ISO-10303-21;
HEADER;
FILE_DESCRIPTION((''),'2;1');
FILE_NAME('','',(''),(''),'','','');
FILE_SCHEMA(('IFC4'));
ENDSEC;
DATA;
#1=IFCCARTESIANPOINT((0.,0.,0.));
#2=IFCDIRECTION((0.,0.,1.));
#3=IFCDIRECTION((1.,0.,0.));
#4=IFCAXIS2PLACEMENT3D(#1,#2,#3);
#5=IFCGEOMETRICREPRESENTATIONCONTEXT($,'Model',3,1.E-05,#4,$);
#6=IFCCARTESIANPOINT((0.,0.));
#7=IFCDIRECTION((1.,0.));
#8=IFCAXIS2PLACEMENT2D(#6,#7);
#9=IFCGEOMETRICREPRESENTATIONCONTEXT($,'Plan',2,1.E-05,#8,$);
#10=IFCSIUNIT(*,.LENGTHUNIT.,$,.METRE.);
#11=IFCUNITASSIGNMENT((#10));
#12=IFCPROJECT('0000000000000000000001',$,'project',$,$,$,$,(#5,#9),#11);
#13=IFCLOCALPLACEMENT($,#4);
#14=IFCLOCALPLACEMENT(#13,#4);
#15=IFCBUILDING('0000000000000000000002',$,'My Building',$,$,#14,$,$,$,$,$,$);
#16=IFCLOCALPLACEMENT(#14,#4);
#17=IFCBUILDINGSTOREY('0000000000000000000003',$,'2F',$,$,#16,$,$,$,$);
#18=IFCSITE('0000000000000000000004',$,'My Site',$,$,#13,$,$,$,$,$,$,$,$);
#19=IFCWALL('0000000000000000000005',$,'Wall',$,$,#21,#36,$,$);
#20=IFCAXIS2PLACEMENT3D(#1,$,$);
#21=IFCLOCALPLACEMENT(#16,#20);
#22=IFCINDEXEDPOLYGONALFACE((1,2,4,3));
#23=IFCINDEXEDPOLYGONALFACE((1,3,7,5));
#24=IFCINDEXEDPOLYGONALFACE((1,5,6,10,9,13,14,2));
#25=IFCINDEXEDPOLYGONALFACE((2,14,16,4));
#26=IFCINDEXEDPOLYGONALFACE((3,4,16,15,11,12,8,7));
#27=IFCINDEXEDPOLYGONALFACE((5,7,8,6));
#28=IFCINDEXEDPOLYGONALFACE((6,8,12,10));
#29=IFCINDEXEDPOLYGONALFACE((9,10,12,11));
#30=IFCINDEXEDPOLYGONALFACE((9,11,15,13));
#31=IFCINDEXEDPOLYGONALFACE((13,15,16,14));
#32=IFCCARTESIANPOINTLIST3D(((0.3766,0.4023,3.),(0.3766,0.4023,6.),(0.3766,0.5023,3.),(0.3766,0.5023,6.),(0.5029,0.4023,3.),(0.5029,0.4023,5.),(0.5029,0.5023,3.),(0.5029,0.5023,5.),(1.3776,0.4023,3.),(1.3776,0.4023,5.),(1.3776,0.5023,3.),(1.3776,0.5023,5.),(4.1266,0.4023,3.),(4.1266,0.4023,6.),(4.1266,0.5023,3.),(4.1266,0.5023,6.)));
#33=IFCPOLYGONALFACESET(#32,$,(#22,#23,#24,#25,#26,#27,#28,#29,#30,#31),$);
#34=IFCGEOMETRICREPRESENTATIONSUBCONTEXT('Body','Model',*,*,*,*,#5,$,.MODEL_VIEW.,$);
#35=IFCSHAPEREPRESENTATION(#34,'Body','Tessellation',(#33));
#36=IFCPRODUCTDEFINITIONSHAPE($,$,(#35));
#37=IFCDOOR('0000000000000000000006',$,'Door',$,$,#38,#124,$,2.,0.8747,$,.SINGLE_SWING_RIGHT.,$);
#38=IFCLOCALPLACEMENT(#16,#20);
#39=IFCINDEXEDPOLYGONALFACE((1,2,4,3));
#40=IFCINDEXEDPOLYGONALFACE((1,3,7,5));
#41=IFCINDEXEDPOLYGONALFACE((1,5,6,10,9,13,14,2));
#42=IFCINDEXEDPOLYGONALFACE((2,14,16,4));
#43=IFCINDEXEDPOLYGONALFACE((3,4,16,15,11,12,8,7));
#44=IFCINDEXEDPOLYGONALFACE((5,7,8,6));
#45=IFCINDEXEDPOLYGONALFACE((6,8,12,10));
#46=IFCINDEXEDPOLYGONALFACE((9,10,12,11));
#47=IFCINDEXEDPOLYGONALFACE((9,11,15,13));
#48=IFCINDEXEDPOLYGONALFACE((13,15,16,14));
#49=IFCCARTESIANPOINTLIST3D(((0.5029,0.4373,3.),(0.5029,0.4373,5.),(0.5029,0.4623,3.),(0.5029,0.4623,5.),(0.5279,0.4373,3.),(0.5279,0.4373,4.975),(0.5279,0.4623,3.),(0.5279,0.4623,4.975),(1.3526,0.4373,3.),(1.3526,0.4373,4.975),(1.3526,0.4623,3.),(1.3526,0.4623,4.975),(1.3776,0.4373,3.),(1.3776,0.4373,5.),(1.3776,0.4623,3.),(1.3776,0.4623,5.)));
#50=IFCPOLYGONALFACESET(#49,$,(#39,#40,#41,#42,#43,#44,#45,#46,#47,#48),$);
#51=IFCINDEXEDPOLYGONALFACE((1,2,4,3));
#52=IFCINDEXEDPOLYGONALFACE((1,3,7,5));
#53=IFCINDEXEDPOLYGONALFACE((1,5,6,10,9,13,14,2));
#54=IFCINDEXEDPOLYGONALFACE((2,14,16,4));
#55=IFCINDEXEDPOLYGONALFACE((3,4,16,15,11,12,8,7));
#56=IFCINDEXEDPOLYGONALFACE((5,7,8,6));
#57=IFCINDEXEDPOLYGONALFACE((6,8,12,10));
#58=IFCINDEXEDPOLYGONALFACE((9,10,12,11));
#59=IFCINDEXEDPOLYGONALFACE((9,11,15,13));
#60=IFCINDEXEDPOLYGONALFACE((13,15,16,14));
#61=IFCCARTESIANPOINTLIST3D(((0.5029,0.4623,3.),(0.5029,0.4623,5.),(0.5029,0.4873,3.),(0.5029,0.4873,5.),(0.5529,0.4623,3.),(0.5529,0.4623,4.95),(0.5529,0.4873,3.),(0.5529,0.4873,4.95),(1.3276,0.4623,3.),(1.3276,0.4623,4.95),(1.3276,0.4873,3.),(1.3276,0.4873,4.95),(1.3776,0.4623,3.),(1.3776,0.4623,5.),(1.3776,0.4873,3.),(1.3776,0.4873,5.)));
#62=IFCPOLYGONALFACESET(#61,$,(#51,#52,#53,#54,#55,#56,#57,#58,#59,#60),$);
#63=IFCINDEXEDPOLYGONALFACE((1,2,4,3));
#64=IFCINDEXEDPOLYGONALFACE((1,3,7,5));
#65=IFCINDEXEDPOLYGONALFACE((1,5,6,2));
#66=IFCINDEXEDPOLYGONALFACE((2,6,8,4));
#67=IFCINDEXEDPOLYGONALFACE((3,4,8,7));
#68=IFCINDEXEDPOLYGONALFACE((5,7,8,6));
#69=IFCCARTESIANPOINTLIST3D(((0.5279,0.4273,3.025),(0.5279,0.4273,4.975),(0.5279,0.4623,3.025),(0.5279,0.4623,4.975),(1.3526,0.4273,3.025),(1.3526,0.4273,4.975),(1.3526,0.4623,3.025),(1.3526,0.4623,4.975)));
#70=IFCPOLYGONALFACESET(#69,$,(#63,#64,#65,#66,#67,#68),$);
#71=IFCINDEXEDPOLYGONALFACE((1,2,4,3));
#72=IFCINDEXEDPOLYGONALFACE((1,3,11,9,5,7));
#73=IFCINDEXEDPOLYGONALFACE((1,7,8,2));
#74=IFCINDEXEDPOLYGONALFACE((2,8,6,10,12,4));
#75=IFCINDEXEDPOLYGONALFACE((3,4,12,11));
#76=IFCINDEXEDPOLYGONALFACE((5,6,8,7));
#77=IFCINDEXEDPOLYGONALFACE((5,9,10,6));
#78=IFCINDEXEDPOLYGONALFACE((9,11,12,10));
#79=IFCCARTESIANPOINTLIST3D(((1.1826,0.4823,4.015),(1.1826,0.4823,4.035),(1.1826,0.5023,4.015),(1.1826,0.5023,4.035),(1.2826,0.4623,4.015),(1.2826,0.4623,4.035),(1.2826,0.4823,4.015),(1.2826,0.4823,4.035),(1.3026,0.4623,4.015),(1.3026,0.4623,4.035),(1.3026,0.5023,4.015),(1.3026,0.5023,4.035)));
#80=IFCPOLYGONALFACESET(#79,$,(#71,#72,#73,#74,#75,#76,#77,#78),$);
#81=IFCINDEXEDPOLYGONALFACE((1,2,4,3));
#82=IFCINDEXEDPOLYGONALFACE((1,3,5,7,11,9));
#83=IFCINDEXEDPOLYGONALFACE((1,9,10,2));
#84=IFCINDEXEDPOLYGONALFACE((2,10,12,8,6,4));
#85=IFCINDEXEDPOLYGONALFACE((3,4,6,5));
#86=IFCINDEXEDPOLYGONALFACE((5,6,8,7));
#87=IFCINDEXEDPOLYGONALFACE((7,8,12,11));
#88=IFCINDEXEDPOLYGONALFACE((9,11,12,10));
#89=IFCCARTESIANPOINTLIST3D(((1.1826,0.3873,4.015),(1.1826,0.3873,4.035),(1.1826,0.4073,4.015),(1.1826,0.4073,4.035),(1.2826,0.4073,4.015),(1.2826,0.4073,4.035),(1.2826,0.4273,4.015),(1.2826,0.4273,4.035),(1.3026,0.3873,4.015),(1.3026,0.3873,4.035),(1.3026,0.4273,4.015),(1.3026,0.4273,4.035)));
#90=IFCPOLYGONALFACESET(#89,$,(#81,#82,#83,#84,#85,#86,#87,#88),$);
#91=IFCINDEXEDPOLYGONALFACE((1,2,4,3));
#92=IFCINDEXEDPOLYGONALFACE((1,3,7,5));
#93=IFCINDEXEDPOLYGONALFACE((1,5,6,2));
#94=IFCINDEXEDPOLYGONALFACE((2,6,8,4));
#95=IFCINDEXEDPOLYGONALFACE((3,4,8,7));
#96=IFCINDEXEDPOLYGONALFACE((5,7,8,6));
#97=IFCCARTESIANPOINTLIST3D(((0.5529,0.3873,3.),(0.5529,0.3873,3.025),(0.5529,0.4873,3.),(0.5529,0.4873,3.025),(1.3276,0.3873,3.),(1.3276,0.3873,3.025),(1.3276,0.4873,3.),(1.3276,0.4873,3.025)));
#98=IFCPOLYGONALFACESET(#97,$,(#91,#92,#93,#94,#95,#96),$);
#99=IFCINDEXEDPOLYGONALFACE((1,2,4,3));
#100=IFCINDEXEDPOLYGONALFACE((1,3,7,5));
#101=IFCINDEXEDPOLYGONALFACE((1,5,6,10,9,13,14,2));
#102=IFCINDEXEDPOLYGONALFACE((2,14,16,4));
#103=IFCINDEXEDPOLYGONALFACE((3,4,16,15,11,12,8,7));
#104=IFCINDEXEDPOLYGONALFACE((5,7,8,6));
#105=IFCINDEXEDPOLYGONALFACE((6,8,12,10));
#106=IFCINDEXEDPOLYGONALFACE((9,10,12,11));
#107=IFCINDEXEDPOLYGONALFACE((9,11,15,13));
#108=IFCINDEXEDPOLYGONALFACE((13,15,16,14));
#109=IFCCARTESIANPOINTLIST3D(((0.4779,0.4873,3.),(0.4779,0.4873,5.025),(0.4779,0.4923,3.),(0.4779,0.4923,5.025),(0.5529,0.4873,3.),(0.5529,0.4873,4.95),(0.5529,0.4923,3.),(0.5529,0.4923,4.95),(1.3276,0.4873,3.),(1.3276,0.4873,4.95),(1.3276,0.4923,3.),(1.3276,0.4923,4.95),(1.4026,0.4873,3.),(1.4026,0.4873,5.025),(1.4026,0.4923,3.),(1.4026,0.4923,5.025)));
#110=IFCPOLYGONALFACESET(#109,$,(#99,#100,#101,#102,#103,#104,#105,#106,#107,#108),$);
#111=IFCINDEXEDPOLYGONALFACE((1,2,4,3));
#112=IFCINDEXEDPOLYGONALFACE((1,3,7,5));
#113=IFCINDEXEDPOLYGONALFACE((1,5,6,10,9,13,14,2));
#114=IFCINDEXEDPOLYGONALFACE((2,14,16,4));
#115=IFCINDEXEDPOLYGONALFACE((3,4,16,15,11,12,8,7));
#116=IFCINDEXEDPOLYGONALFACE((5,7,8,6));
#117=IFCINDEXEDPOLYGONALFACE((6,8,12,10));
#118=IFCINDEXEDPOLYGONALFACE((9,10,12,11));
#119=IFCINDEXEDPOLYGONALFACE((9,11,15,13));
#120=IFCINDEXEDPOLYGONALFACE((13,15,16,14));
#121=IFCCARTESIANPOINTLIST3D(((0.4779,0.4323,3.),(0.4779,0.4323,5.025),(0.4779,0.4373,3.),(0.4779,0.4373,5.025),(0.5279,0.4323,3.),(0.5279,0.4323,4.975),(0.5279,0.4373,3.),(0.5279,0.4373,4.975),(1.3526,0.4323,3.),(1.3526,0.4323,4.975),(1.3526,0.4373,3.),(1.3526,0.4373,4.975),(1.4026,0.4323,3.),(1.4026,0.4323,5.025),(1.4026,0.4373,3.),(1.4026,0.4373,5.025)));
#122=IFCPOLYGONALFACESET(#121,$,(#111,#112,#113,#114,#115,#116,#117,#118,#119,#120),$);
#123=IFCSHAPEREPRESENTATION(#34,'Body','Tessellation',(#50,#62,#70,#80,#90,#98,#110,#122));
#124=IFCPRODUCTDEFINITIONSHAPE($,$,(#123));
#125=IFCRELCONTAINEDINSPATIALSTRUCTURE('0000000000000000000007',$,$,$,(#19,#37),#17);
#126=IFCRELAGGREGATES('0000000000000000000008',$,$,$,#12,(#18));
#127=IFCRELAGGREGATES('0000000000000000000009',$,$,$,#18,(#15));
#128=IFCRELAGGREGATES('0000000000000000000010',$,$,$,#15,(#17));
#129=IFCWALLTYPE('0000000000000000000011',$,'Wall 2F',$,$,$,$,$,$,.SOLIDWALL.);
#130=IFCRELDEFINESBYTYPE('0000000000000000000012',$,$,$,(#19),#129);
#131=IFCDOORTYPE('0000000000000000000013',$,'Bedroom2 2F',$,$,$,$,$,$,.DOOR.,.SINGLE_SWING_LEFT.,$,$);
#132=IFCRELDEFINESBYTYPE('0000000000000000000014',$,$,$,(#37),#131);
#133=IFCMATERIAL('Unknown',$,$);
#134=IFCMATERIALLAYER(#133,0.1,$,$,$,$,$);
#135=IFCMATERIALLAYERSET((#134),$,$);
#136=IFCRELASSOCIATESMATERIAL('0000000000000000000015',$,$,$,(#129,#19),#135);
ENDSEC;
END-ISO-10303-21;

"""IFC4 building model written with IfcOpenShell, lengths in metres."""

from ifc_helpers import new_model, entity, si_unit, frame, origin_with_axes, origin_2d_with_axis, place, context, subcontext, project, spatial, line, indexed_curve, outline, extrude, shape, source, transform, mapped, material, layer, layer_set, layer_usage, type_object, type_shapes, element, fill, save


model = new_model("IFC4")

# Units and contexts
model_context = context("Model", 3, precision=1e-05, world=origin_with_axes())
plan_context = context("Plan", 2, precision=1e-05, world=origin_2d_with_axis())
body_context_1 = subcontext(model_context, "Body", "Model", "MODEL_VIEW")
body_context_2 = subcontext(plan_context, "Body", "Plan", "PLAN_VIEW")
ifc_project = project(units=[si_unit("LENGTHUNIT", "METRE")], contexts=[model_context, plan_context])

# Site, building, storey
site_placement = place(None, origin_with_axes())
site = spatial("IfcSite", under=ifc_project, at=site_placement, Name="My Site")
building_placement = place(site_placement, origin_with_axes())
building = spatial("IfcBuilding", under=site, at=building_placement, Name="My Building")
storey_placement = place(building_placement, origin_with_axes())
storey = spatial("IfcBuildingStorey", under=building, at=storey_placement, Name="2F")

# Shared definitions
ifc_material = material(Name="Unknown")

# Shared definitions
ifc_layer = layer(ifc_material, 0.1)
ifc_layer_set = layer_set([ifc_layer])
wall_type = type_object("IfcWallType", Name="Wall 2F", PredefinedType="SOLIDWALL", material=ifc_layer_set)

# Wall, opening, door
ifc_layer_usage_1 = layer_usage(ifc_layer_set, "AXIS2", "POSITIVE", 0.0)
wall_1_placement = place(storey_placement, frame((4.2266, 0.5023, 3.0), z_axis=(0.0, 0.0, 1.0), x_axis=(-1.0, 0.0, 0.0)))
wall_1 = element("IfcWall", 1, at=wall_1_placement, inside=storey, type_object=wall_type, material=ifc_layer_usage_1, Name="Wall", context=body_context_1, shape_type="SweptSolid", body=[
    extrude(outline(indexed_curve([(0.1, 0.0), (0.1, 0.1), (3.85, 0.1), (3.85, 0.0)], segments=[line(1, 2, 3, 4, 1)])), origin_with_axes(), (0.0, 0.0, 1.0), 3.0),
])
shared_shape_1 = source(origin_with_axes(), body_context_1, "Body", "SweptSolid", [
    extrude(outline(indexed_curve([(0.0, 0.0), (0.8747, 0.0), (0.8747, 2.0), (0.0, 2.0)], segments=[line(1, 2, 3, 4, 1)])), frame((0.0, -0.6, 0.0), z_axis=(0.0, -1.0, 0.0), x_axis=(1.0, 0.0, 0.0)), (0.0, 0.0, -1.0), 1.2),
])
opening_1_placement = place(wall_1_placement, frame((2.849, 0.015, 0.0), z_axis=(0.0, 0.0, 1.0), x_axis=(1.0, -0.000001, 0.0)))
opening_1 = element("IfcOpeningElement", 2, at=opening_1_placement, cuts=wall_1, PredefinedType="OPENING", context=body_context_1, shape_type="MappedRepresentation", body=[
    mapped(shared_shape_1, transform((0.0, 0.0, 0.0), x_axis=(1.0, 0.0, 0.0), y_axis=(0.0, 1.0, 0.0), z_axis=(0.0, 0.0, 1.0), scale=1.0)),
])
door_type_1 = type_object("IfcDoorType", Name="Bedroom2 2F", OperationType="SINGLE_SWING_LEFT", PredefinedType="DOOR")
shared_shape_2 = source(origin_with_axes(), body_context_1, "Body", "SweptSolid", [
    extrude(outline(indexed_curve([(0.0, 0.0), (0.0, 2.0), (0.8747, 2.0), (0.8747, 0.0), (0.8497, 0.0), (0.8497, 1.975), (0.025, 1.975), (0.025, 0.0)], segments=[line(1, 2, 3, 4, 5, 6, 7, 8, 1)])), frame((0.0, 0.025, 0.0), z_axis=(0.0, -1.0, 0.0), x_axis=(1.0, 0.0, 0.0)), (0.0, 0.0, -1.0), 0.025),
    extrude(outline(indexed_curve([(0.0, 0.0), (0.0, 2.0), (0.8747, 2.0), (0.8747, 0.0), (0.8247, 0.0), (0.8247, 1.95), (0.05, 1.95), (0.05, 0.0)], segments=[line(1, 2, 3, 4, 5, 6, 7, 8, 1)])), frame((0.0, 0.0, 0.0), z_axis=(0.0, -1.0, 0.0), x_axis=(1.0, 0.0, 0.0)), (0.0, 0.0, -1.0), 0.025),
    extrude(outline(indexed_curve([(0.0, 0.0), (0.8247, 0.0), (0.8247, 0.035), (0.0, 0.035)], segments=[line(1, 2, 3, 4, 1)])), frame((0.025, 0.025, 0.025), z_axis=(0.0, 0.0, 1.0), x_axis=(1.0, 0.0, 0.0)), (0.0, 0.0, 1.0), 1.95),
    extrude(outline(indexed_curve([(0.0, 0.0), (0.0, -0.04), (0.12, -0.04), (0.12, -0.02), (0.02, -0.02), (0.02, 0.0)], segments=[line(1, 2, 3, 4, 5, 6, 1)])), frame((0.075, 0.025, 1.015), z_axis=(0.0, 0.0, 1.0), x_axis=(1.0, 0.0, 0.0)), (0.0, 0.0, 1.0), 0.02),
    extrude(outline(indexed_curve([(0.0, 0.0), (0.0, 0.04), (0.12, 0.04), (0.12, 0.02), (0.02, 0.02), (0.02, 0.0)], segments=[line(1, 2, 3, 4, 5, 6, 1)])), frame((0.075, 0.06, 1.015), z_axis=(0.0, 0.0, 1.0), x_axis=(1.0, 0.0, 0.0)), (0.0, 0.0, 1.0), 0.02),
    extrude(outline(indexed_curve([(0.0, 0.0), (0.7747, 0.0), (0.7747, 0.1), (0.0, 0.1)], segments=[line(1, 2, 3, 4, 1)])), frame((0.05, 0.0, 0.0), z_axis=(0.0, 0.0, 1.0), x_axis=(1.0, 0.0, 0.0)), (0.0, 0.0, 1.0), 0.025),
    extrude(outline(indexed_curve([(0.0, 0.0), (0.0, 2.025), (0.9247, 2.025), (0.9247, 0.0), (0.8497, 0.0), (0.8497, 1.95), (0.075, 1.95), (0.075, 0.0)], segments=[line(1, 2, 3, 4, 5, 6, 7, 8, 1)])), frame((-0.025, -0.005, 0.0), z_axis=(0.0, -1.0, 0.0), x_axis=(1.0, 0.0, 0.0)), (0.0, 0.0, -1.0), 0.005),
    extrude(outline(indexed_curve([(0.0, 0.0), (0.0, 2.025), (0.9247, 2.025), (0.9247, 0.0), (0.8747, 0.0), (0.8747, 1.975), (0.05, 1.975), (0.05, 0.0)], segments=[line(1, 2, 3, 4, 5, 6, 7, 8, 1)])), frame((-0.025, 0.05, 0.0), z_axis=(0.0, -1.0, 0.0), x_axis=(1.0, 0.0, 0.0)), (0.0, 0.0, -1.0), 0.005),
])
shared_shape_3 = source(origin_with_axes(), body_context_2, "Body", "Curve2D", [
    entity("IfcIndexedPolyCurve", entity("IfcCartesianPointList2D", [[0.0, 0.0], [0.0, 0.05], [0.025, 0.05], [0.025, 0.025], [0.05, 0.025], [0.05, 0.0]]), [entity("IfcLineIndex", [1, 2, 3, 4, 5, 6, 1])]),
    entity("IfcIndexedPolyCurve", entity("IfcCartesianPointList2D", [[0.8747, 0.0], [0.8747, 0.05], [0.8497, 0.05], [0.8497, 0.025], [0.8247, 0.025], [0.8247, 0.0]]), [entity("IfcLineIndex", [1, 2, 3, 4, 5, 6, 1])]),
    entity("IfcTrimmedCurve", entity("IfcEllipse", entity("IfcAxis2Placement2D", entity("IfcCartesianPoint", [0.8147, 0.05]), entity("IfcDirection", [1.0, 0.0])), 0.7897, 0.8247), [entity("IfcCartesianPoint", [0.8147, 0.8747])], [entity("IfcCartesianPoint", [0.025, 0.05])], True, "CARTESIAN"),
    entity("IfcIndexedPolyCurve", entity("IfcCartesianPointList2D", [[0.8497, 0.05], [0.8147, 0.05], [0.8147, 0.8747], [0.8497, 0.8747]]), [entity("IfcLineIndex", [1, 2, 3, 4, 1])]),
])
type_shapes(door_type_1, [shared_shape_2, shared_shape_3])
door_1_placement = place(opening_1_placement, frame((0.0, 0.0, 0.0), z_axis=(0.0, 0.0, 1.0), x_axis=(1.0, 0.0, 0.0)))
door_1 = element("IfcDoor", 3, at=door_1_placement, inside=storey, type_object=door_type_1, Name="Door", OperationType="SINGLE_SWING_RIGHT", OverallHeight=2.0, OverallWidth=0.8747, shapes=[
    shape(body_context_1, "Body", "MappedRepresentation", [mapped(shared_shape_2, transform((0.0, 0.0, 0.0), x_axis=(1.0, 0.0, 0.0), y_axis=(0.0, 1.0, 0.0), z_axis=(0.0, 0.0, 1.0), scale=1.0))]),
    shape(body_context_2, "Body", "MappedRepresentation", [mapped(shared_shape_3, transform((0.0, 0.0, 0.0), x_axis=(1.0, 0.0, 0.0), y_axis=(0.0, 1.0, 0.0), z_axis=(0.0, 0.0, 1.0), scale=1.0))]),
])
fill(opening_1, door_1)

save(model, "model.ifc")
